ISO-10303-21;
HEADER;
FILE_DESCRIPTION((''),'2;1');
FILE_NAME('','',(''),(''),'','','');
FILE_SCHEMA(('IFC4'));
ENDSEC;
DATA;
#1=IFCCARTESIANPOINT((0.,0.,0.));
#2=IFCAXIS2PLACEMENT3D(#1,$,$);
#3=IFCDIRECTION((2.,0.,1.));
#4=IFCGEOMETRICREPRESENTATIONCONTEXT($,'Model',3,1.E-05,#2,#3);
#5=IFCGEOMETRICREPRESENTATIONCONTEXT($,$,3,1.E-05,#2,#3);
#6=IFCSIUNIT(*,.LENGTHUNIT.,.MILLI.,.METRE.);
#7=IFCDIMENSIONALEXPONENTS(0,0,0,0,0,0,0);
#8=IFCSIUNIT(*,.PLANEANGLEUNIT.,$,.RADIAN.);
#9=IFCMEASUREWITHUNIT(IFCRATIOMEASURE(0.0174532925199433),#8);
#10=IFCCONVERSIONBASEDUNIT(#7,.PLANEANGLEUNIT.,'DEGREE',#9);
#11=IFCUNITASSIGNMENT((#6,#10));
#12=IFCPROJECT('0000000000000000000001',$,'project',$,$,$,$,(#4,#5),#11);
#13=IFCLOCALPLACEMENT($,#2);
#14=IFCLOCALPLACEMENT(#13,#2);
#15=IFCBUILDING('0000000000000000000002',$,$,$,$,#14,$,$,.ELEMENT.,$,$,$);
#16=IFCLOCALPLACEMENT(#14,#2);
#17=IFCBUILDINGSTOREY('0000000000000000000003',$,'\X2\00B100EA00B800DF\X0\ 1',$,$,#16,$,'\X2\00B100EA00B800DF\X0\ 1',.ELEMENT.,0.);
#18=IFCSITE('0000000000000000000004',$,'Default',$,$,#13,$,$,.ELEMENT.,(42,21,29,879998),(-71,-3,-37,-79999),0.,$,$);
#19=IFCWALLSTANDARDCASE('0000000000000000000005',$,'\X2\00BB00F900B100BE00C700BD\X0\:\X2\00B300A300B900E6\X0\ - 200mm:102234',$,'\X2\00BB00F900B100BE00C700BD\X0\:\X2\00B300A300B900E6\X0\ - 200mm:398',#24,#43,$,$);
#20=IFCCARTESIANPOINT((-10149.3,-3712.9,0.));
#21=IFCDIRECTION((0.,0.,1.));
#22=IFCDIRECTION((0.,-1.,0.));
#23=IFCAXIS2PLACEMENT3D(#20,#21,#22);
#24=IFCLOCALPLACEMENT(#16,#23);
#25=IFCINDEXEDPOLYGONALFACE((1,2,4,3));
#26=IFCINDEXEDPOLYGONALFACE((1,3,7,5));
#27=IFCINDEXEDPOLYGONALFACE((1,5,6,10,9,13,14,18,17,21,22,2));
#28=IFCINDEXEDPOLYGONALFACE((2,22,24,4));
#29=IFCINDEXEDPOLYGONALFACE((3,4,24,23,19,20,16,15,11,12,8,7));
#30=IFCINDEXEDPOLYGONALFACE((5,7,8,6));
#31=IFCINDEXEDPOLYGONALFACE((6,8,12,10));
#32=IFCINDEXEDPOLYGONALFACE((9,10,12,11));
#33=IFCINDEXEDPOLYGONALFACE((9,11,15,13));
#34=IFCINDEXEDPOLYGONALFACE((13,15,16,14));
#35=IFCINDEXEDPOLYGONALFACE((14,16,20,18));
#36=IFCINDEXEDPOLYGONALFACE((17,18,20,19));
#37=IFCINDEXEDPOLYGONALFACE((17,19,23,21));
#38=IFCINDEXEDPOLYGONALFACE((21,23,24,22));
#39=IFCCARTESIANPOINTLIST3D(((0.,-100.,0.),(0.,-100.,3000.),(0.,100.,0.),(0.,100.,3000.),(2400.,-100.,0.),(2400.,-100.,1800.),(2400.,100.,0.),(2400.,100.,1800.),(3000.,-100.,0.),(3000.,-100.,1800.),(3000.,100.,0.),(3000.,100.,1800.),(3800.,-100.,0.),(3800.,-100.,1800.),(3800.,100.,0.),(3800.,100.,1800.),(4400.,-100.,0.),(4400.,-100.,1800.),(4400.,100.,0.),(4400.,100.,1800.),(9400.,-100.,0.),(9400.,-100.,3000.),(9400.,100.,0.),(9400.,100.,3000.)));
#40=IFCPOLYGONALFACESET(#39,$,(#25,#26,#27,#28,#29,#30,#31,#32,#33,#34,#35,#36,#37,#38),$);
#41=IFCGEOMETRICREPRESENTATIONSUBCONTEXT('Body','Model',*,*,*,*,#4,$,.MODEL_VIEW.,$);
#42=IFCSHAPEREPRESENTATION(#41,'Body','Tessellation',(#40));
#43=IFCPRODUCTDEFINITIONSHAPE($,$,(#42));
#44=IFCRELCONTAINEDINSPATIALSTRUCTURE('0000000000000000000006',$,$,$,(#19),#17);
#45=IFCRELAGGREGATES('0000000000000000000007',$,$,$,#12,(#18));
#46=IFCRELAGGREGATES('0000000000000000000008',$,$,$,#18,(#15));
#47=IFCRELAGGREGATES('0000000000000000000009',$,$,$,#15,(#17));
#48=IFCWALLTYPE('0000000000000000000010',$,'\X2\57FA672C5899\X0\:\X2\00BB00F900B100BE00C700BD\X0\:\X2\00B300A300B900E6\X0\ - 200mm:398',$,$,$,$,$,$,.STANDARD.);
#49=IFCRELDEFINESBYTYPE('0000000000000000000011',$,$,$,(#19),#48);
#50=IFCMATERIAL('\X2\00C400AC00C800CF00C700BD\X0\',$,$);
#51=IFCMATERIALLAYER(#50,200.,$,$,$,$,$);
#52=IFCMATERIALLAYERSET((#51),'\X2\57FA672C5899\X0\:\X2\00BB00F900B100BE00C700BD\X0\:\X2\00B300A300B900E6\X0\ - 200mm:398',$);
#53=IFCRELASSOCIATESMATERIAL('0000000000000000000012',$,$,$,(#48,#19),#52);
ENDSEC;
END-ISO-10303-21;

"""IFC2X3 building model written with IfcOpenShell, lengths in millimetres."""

from ifc_helpers import new_model, entity, si_unit, converted_unit, direction, frame, frame_2d, origin, place, context, subcontext, project, spatial, rectangle, extrude, material, layer, layer_set, layer_usage, type_object, element, save


model = new_model("IFC2X3")

# Units and contexts
model_context = context("Model", 3, precision=1e-05, world=origin(), true_north=direction((2.0, 0.0, 1.0)))
context_of_model = context(None, 3, precision=1e-05, world=origin(), true_north=direction((2.0, 0.0, 1.0)))
body_context = subcontext(model_context, "Body", "Model", "MODEL_VIEW")
ifc_project = project(units=[si_unit("LENGTHUNIT", "METRE", prefix="MILLI"), converted_unit("PLANEANGLEUNIT", "DEGREE", entity("IfcRatioMeasure", 0.0174532925199433), si_unit("PLANEANGLEUNIT", "RADIAN"), dimensions=[0, 0, 0, 0, 0, 0, 0])], contexts=[model_context, context_of_model])

# Site, building, storey
site_placement = place(None, origin())
site = spatial("IfcSite", under=ifc_project, at=site_placement, Name="Default", CompositionType="ELEMENT", RefLatitude=(42, 21, 29, 879998), RefLongitude=(-71, -3, -37, -79999), RefElevation=0.0)
building_placement = place(site_placement, origin())
building = spatial("IfcBuilding", under=site, at=building_placement, CompositionType="ELEMENT")
storey_placement = place(building_placement, origin())
storey = spatial("IfcBuildingStorey", under=building, at=storey_placement, Name="±ê¸ß 1", LongName="±ê¸ß 1", CompositionType="ELEMENT", Elevation=0.0)

# Shared definitions
ifc_material_1 = material(Name="Ä¬ÈÏÇ½")
ifc_layer_1 = layer(ifc_material_1, 200.0)
ifc_layer_set_1 = layer_set([ifc_layer_1], Name="基本墙:»ù±¾Ç½:³£¹æ - 200mm:398")
wall_type = type_object("IfcWallType", Name="基本墙:»ù±¾Ç½:³£¹æ - 200mm:398", PredefinedType="STANDARD", material=ifc_layer_set_1)

# Wall, openings
ifc_layer_usage_1 = layer_usage(ifc_layer_set_1, "AXIS2", "NEGATIVE", 100.0)
wall_1_placement = place(storey_placement, frame((-10149.3, -3712.9, 0.0), z_axis=(0.0, 0.0, 1.0), x_axis=(0.0, -1.0, 0.0)))
wall_1 = element("IfcWallStandardCase", 1, at=wall_1_placement, inside=storey, type_object=wall_type, material=ifc_layer_usage_1, Name="»ù±¾Ç½:³£¹æ - 200mm:102234", ObjectType="»ù±¾Ç½:³£¹æ - 200mm:398", context=body_context, shape_type="SweptSolid", body=[
    extrude(rectangle(XDim=9400.0, YDim=200.0, at=frame_2d((4700.0, 0.0), x_axis=(-1.0, 0.0))), origin(), (0.0, 0.0, 1.0), 3000.0),
])
opening_1_placement = place(wall_1_placement, origin())
element("IfcOpeningElement", 2, at=opening_1_placement, cuts=wall_1, ObjectType="Opening", context=body_context, shape_type="SweptSolid", body=[
    extrude(rectangle(XDim=1800.0, YDim=600.0, at=frame_2d((0.0, 0.0), x_axis=(0.0, 1.0))), frame((2700.0, -102.0, 900.0), z_axis=(0.0, 1.0, 0.0), x_axis=(1.0, 0.0, 0.0)), (0.0, 0.0, 1.0), 204.0),
])
opening_2_placement = place(wall_1_placement, origin())
element("IfcOpeningElement", 3, at=opening_2_placement, cuts=wall_1, ObjectType="Opening", context=body_context, shape_type="SweptSolid", body=[
    extrude(rectangle(XDim=1800.0, YDim=600.0, at=frame_2d((0.0, 0.0), x_axis=(0.0, 1.0))), frame((4100.0, -102.0, 900.0), z_axis=(0.0, 1.0, 0.0), x_axis=(1.0, 0.0, 0.0)), (0.0, 0.0, 1.0), 204.0),
])

save(model, "model.ifc")
